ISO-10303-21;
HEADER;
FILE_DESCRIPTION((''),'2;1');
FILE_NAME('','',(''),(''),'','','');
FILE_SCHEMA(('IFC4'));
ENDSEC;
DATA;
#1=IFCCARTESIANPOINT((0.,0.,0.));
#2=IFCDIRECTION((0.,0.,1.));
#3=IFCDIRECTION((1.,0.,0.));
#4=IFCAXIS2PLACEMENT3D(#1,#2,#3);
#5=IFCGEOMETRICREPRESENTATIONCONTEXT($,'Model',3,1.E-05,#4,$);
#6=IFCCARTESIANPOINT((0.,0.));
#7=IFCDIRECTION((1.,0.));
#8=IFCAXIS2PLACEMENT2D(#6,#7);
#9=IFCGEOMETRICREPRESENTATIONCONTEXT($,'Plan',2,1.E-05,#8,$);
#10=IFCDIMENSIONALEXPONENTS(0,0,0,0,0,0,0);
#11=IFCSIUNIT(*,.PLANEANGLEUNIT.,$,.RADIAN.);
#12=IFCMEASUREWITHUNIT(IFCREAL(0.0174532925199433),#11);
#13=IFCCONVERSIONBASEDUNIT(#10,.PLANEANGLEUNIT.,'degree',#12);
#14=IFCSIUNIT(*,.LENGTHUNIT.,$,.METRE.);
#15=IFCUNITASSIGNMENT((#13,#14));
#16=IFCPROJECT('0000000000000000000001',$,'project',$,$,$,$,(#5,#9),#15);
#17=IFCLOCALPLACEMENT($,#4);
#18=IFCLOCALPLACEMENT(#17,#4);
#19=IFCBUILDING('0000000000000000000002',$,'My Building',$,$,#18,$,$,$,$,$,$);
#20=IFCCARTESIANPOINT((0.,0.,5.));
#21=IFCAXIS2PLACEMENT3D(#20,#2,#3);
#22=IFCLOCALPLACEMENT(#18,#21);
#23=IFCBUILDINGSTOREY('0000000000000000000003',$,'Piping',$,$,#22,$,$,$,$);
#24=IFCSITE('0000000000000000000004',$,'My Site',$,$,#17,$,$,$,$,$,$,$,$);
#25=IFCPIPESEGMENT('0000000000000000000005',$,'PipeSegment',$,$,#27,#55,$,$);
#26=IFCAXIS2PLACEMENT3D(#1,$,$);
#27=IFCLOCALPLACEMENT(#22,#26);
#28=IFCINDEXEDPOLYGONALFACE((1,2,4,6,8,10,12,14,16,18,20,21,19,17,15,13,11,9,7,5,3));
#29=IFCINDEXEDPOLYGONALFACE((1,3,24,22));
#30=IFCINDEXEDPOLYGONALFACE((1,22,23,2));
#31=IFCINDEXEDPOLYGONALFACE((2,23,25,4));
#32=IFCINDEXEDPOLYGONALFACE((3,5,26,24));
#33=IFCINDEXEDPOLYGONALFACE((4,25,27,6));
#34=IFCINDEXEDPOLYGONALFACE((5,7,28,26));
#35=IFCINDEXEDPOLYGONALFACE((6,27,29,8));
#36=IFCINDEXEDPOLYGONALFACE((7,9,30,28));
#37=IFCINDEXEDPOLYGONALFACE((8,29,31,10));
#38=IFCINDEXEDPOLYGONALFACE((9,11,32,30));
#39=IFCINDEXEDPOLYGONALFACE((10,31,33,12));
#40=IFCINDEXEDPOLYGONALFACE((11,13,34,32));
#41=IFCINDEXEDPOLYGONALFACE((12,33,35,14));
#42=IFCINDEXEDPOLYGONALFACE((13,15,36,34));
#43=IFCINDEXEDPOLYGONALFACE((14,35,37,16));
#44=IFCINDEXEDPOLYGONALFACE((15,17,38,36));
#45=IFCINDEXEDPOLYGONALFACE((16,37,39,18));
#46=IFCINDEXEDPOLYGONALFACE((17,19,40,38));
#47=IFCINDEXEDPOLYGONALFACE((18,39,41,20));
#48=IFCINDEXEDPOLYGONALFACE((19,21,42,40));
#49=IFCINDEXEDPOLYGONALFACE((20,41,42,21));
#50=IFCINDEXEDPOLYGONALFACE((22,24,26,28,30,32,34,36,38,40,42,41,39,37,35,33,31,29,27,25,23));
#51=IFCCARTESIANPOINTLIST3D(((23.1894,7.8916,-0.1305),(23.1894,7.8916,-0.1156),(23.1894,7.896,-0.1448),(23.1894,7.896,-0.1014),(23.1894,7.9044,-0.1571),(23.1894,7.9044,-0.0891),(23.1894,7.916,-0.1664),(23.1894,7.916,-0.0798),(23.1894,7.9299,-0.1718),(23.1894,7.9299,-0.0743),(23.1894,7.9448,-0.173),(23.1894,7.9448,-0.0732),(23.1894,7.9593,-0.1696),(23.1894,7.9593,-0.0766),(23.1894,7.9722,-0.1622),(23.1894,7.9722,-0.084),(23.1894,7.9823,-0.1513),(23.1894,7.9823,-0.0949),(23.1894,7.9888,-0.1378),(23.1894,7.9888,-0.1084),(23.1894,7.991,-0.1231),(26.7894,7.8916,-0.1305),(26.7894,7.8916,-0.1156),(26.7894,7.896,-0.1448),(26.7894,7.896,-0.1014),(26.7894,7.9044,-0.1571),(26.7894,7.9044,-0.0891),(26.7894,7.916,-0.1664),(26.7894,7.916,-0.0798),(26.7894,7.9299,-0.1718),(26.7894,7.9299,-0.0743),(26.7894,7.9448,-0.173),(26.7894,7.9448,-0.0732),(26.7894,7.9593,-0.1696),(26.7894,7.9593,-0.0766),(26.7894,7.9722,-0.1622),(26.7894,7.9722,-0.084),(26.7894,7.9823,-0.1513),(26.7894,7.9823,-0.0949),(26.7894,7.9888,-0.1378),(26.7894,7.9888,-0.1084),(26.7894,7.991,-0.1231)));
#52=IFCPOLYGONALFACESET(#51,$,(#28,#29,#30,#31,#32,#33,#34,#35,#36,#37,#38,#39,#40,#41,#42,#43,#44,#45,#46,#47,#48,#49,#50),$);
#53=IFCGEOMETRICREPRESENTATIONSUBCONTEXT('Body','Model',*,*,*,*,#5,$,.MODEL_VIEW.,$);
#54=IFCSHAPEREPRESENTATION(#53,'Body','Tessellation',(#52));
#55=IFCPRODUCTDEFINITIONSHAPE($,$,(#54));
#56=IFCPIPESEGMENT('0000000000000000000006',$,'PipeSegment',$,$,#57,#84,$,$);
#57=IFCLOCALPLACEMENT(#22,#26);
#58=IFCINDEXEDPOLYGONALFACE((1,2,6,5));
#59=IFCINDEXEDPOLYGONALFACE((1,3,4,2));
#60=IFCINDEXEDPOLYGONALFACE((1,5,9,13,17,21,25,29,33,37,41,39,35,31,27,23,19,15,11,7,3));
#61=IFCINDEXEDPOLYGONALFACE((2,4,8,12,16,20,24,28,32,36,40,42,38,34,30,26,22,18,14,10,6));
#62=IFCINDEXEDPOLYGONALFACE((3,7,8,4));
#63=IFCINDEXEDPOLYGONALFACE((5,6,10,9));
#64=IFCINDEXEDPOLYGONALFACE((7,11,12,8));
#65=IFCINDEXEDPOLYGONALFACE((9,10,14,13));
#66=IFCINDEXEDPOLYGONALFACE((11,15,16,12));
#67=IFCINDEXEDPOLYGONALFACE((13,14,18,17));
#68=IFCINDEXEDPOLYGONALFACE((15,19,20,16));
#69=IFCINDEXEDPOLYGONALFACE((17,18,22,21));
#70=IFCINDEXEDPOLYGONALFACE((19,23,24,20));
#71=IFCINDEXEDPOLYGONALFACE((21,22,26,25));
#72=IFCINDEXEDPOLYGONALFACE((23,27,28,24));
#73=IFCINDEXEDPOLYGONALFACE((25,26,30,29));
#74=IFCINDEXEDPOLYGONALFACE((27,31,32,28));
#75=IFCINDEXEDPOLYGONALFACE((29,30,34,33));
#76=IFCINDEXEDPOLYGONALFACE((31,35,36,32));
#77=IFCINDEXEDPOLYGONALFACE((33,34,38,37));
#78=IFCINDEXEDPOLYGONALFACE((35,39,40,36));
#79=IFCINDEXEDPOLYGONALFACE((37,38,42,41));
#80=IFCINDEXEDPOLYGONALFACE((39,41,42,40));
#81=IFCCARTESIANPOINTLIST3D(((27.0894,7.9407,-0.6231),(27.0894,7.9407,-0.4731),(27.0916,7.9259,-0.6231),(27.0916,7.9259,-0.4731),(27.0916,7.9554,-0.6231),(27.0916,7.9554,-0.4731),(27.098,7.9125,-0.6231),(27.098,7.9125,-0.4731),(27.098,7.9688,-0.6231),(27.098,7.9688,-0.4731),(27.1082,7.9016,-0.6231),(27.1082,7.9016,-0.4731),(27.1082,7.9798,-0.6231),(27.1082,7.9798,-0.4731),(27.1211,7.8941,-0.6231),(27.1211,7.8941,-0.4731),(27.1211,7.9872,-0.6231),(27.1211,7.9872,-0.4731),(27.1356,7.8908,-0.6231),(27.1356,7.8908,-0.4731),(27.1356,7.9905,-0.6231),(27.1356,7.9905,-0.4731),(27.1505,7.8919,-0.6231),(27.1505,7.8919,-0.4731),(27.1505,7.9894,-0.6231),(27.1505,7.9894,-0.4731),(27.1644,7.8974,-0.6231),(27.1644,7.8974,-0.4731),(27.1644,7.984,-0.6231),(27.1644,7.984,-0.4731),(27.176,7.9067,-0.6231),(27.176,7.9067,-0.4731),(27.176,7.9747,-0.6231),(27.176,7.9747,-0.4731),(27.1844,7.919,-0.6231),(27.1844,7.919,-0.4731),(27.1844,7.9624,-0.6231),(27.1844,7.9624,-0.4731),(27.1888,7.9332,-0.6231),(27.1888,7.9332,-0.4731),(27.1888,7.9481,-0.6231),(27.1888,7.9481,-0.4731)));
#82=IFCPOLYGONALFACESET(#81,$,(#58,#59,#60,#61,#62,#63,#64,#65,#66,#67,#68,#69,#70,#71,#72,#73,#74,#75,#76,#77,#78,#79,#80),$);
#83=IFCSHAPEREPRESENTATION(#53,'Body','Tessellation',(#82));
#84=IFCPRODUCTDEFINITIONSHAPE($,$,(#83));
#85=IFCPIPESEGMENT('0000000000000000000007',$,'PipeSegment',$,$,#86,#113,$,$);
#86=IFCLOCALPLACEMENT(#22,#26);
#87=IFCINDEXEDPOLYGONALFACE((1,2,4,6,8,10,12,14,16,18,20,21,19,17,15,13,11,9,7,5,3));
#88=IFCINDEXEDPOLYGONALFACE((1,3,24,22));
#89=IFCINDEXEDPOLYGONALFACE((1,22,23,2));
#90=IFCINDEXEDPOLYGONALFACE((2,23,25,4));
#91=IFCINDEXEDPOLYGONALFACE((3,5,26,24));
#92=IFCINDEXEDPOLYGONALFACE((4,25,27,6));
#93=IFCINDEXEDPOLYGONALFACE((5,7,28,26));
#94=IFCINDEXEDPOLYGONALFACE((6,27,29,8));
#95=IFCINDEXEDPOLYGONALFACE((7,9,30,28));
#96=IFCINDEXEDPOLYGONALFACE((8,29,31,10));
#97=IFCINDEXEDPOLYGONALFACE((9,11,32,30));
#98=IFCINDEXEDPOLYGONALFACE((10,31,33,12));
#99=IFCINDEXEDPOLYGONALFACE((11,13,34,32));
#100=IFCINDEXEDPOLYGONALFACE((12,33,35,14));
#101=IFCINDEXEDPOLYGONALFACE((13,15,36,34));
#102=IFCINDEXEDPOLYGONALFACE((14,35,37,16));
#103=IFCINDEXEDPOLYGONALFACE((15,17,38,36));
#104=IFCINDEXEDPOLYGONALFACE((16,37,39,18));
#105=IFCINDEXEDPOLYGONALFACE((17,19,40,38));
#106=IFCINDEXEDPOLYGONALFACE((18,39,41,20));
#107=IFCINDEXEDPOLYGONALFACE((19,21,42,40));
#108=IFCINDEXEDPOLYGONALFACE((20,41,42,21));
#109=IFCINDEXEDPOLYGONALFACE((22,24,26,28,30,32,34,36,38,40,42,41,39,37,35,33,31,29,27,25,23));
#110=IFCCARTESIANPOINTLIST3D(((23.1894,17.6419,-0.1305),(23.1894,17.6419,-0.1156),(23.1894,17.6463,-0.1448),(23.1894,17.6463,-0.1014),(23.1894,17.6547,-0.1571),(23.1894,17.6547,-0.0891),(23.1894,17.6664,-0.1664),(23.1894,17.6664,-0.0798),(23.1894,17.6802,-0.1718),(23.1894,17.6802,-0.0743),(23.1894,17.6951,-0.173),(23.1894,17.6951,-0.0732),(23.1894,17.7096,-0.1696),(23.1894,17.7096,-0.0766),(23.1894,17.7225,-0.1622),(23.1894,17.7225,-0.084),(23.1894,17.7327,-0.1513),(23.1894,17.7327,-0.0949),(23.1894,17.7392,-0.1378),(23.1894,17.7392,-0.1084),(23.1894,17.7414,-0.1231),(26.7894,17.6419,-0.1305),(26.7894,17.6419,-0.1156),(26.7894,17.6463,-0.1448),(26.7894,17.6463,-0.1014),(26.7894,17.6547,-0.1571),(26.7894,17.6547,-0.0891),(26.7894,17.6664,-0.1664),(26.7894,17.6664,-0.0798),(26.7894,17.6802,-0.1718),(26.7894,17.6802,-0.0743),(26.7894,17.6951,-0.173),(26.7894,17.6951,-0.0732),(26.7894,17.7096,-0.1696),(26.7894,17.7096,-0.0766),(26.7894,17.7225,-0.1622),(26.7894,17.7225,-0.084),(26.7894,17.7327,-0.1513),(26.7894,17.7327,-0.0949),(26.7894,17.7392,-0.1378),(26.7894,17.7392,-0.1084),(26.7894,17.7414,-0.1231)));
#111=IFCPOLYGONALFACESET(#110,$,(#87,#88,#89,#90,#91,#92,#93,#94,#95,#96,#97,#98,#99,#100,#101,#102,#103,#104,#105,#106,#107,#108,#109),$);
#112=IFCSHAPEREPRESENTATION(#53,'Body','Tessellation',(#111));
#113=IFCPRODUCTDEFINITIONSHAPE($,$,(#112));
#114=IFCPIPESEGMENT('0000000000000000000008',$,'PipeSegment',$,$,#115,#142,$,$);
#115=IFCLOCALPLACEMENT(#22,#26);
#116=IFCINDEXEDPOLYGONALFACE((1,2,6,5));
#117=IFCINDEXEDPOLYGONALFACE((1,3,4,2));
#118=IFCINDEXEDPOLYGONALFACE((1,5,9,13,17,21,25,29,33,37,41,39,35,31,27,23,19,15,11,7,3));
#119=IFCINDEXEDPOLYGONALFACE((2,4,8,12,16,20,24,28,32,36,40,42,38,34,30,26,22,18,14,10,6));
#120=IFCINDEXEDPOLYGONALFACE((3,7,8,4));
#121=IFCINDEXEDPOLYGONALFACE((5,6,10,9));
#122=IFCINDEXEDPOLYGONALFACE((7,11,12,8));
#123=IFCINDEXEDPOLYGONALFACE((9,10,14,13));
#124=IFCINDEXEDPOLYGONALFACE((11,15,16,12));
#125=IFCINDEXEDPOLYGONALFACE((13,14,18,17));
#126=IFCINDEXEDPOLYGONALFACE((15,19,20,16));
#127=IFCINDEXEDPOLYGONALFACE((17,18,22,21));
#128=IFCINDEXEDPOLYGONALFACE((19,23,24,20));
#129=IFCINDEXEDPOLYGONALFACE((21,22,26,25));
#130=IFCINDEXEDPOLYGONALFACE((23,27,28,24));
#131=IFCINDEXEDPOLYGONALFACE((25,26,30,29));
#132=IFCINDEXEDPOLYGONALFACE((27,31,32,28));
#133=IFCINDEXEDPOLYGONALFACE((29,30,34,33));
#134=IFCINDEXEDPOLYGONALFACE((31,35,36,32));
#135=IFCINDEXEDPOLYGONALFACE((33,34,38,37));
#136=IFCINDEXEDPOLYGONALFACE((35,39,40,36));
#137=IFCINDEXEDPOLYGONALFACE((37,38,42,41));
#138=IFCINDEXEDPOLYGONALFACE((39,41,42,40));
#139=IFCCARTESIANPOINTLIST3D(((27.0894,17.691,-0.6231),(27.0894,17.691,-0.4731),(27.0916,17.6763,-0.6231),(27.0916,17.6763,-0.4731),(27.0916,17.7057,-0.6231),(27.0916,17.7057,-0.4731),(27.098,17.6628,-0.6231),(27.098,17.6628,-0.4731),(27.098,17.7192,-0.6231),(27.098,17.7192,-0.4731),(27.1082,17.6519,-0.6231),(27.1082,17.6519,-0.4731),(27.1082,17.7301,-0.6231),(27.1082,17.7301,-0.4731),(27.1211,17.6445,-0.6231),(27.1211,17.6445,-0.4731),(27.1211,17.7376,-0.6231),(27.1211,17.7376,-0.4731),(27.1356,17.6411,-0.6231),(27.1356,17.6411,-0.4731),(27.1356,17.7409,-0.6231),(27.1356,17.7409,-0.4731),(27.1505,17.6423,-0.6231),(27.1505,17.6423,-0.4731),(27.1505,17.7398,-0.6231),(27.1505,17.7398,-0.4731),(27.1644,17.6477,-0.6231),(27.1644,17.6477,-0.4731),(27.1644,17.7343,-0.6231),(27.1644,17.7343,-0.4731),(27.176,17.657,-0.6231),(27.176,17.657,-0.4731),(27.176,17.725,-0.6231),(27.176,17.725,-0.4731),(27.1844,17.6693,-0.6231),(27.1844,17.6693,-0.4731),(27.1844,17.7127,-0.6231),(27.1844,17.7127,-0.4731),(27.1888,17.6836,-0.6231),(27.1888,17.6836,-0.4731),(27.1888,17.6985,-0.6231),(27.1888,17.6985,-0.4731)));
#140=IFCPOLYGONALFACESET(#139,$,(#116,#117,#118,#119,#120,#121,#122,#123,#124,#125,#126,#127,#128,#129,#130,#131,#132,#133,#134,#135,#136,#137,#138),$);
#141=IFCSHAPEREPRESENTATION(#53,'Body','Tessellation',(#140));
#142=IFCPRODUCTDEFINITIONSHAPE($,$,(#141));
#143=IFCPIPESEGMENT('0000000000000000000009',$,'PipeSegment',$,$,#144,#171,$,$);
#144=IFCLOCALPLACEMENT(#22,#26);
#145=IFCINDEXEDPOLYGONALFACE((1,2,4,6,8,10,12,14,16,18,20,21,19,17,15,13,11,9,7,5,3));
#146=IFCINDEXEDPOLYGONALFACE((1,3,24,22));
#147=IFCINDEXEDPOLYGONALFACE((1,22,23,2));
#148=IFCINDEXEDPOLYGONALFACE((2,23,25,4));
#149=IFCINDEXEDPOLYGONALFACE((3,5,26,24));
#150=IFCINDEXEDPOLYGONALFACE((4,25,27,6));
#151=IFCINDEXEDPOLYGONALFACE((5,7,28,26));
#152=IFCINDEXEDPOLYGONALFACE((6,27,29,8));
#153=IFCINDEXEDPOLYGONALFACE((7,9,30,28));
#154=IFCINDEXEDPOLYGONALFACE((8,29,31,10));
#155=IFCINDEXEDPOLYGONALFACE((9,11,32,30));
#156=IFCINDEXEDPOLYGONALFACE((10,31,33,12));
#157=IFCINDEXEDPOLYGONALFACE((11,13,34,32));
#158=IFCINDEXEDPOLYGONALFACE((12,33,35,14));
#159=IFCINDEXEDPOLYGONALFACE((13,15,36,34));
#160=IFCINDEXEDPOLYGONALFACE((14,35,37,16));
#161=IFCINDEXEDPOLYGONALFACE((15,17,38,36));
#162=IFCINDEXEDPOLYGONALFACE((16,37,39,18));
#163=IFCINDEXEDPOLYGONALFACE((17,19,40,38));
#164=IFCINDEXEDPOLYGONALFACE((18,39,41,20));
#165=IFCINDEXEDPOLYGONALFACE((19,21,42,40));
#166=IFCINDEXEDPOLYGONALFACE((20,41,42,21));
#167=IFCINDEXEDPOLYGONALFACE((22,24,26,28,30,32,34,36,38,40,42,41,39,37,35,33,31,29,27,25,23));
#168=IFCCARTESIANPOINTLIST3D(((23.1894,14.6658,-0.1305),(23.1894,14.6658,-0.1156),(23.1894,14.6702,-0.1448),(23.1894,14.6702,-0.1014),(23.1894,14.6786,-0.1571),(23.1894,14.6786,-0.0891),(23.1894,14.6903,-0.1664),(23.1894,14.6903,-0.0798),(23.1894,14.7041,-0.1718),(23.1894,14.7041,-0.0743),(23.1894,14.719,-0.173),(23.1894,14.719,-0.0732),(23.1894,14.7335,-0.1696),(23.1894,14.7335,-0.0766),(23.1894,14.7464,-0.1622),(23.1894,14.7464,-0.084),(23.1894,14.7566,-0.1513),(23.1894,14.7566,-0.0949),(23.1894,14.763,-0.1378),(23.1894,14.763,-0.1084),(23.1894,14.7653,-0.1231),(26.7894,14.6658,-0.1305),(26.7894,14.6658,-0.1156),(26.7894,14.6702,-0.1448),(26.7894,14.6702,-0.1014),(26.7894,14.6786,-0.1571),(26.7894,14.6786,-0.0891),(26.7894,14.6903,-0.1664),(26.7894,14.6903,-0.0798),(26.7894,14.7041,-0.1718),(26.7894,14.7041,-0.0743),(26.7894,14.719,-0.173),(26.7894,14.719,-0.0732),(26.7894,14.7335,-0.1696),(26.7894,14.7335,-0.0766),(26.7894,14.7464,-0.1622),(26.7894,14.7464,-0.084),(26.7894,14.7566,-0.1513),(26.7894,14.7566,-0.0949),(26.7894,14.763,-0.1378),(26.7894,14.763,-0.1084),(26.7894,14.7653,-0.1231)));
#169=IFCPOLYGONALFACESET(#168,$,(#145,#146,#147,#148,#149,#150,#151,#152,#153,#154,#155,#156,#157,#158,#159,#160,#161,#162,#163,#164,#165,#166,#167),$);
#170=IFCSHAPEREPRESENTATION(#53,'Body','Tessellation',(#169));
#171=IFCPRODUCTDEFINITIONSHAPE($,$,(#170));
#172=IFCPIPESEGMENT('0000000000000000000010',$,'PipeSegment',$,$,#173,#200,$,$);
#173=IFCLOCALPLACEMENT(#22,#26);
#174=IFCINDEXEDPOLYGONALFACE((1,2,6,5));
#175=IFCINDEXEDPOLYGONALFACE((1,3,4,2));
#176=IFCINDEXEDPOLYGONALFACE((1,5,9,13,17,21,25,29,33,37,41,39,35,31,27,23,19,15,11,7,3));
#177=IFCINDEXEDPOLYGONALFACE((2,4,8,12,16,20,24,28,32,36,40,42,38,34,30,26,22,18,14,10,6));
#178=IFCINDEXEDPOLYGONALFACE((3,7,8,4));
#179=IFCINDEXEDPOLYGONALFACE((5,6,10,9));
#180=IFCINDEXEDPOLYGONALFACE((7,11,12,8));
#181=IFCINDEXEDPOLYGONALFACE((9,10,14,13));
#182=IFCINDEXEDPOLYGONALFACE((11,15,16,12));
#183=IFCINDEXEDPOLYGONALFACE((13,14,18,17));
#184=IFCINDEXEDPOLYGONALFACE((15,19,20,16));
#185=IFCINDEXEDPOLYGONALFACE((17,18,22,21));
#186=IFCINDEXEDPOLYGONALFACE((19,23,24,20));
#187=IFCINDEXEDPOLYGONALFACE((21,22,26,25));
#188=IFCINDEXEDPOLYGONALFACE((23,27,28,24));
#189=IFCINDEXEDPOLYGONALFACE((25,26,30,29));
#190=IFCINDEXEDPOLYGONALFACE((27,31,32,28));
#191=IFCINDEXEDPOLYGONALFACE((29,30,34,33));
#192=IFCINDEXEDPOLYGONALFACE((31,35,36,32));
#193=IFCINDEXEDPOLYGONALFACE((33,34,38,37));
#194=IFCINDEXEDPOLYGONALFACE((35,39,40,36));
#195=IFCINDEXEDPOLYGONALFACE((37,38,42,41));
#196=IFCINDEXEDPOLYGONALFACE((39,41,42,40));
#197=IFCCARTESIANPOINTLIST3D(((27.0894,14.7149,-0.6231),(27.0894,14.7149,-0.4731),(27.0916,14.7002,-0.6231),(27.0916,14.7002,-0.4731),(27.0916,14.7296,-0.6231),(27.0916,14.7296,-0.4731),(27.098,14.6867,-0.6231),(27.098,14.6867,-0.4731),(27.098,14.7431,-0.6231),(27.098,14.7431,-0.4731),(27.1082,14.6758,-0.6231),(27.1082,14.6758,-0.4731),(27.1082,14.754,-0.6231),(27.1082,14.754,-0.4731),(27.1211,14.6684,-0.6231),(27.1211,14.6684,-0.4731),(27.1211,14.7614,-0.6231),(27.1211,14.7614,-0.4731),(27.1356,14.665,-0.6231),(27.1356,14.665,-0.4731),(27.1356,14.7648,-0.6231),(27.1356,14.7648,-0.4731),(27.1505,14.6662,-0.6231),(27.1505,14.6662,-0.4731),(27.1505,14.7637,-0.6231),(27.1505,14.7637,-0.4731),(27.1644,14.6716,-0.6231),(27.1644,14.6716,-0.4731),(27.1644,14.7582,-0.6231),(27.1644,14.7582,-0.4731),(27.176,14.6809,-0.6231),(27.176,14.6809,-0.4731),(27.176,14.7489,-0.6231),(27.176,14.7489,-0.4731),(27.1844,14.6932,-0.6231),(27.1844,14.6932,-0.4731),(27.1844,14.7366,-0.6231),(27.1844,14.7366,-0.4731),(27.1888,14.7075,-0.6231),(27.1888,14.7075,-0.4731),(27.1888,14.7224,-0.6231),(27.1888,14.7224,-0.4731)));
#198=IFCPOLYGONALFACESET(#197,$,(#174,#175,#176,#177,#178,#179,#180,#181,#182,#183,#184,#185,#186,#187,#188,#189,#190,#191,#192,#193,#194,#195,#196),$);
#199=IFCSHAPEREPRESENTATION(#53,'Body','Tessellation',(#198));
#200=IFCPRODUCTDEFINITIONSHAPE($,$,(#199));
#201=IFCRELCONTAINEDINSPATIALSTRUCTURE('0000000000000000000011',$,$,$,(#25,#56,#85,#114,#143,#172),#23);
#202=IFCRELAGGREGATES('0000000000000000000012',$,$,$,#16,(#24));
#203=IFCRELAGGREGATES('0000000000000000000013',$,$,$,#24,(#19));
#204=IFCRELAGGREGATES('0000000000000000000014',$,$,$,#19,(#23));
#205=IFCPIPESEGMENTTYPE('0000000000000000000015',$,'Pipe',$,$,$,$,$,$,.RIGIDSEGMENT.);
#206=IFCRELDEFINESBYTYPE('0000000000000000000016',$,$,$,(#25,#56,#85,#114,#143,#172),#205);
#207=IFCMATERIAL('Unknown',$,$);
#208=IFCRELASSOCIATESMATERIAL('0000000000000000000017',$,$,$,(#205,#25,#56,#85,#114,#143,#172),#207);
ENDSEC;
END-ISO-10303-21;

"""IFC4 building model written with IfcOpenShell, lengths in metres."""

from ifc_helpers import new_model, entity, si_unit, converted_unit, frame, origin_with_axes, origin_2d_with_axis, place, context, subcontext, project, spatial, circle, extrude, material, material_profile, profile_set, profile_usage, type_object, element, save


model = new_model("IFC4")

# Units and contexts
model_context = context("Model", 3, precision=1e-05, world=origin_with_axes())
plan_context = context("Plan", 2, precision=1e-05, world=origin_2d_with_axis())
body_context = subcontext(model_context, "Body", "Model", "MODEL_VIEW")
ifc_project = project(units=[converted_unit("PLANEANGLEUNIT", "degree", entity("IfcReal", 0.0174532925199433), si_unit("PLANEANGLEUNIT", "RADIAN"), dimensions=[0, 0, 0, 0, 0, 0, 0]), si_unit("LENGTHUNIT", "METRE")], contexts=[model_context, plan_context])

# Site, building, storey
site_placement = place(None, origin_with_axes())
site = spatial("IfcSite", under=ifc_project, at=site_placement, Name="My Site")
building_placement = place(site_placement, origin_with_axes())
building = spatial("IfcBuilding", under=site, at=building_placement, Name="My Building")
storey_placement = place(building_placement, frame((0.0, 0.0, 5.0), z_axis=(0.0, 0.0, 1.0), x_axis=(1.0, 0.0, 0.0)))
storey = spatial("IfcBuildingStorey", under=building, at=storey_placement, Name="Piping")

# Pipe segments
ifc_material = material(Name="Unknown")
ifc_material_profile_1 = material_profile(ifc_material, circle(Radius=0.05))
ifc_profile_set_1 = profile_set([ifc_material_profile_1])
pipe_segment_type = type_object("IfcPipeSegmentType", Name="Pipe", PredefinedType="RIGIDSEGMENT", material=ifc_profile_set_1)
ifc_profile_usage_1 = profile_usage(ifc_profile_set_1, cardinal=5)
pipe_segment_1_placement = place(storey_placement, frame((23.1894, 7.941, -0.1231), z_axis=(1.0, 0.0, 0.0), x_axis=(0.0, 1.0, 0.0)))
element("IfcPipeSegment", 1, at=pipe_segment_1_placement, inside=storey, type_object=pipe_segment_type, material=ifc_profile_usage_1, Name="PipeSegment", context=body_context, shape_type="SweptSolid", body=[
    extrude(circle(Radius=0.05), origin_with_axes(), (0.0, 0.0, 1.0), 3.6),
])
ifc_profile_usage_2 = profile_usage(ifc_profile_set_1, cardinal=5)
pipe_segment_2_placement = place(storey_placement, frame((27.1394, 7.9407, -0.4731), z_axis=(0.0, 0.0, -1.0), x_axis=(-1.0, 0.0, 0.0)))
element("IfcPipeSegment", 2, at=pipe_segment_2_placement, inside=storey, type_object=pipe_segment_type, material=ifc_profile_usage_2, Name="PipeSegment", context=body_context, shape_type="SweptSolid", body=[
    extrude(circle(Radius=0.05), origin_with_axes(), (0.0, 0.0, 1.0), 0.15),
])
ifc_profile_usage_3 = profile_usage(ifc_profile_set_1, cardinal=5)
pipe_segment_3_placement = place(storey_placement, frame((23.1894, 17.6914, -0.1231), z_axis=(1.0, 0.0, 0.0), x_axis=(0.0, 1.0, 0.0)))
element("IfcPipeSegment", 3, at=pipe_segment_3_placement, inside=storey, type_object=pipe_segment_type, material=ifc_profile_usage_3, Name="PipeSegment", context=body_context, shape_type="SweptSolid", body=[
    extrude(circle(Radius=0.05), origin_with_axes(), (0.0, 0.0, 1.0), 3.6),
])
ifc_profile_usage_4 = profile_usage(ifc_profile_set_1, cardinal=5)
pipe_segment_4_placement = place(storey_placement, frame((27.1394, 17.691, -0.4731), z_axis=(0.0, 0.0, -1.0), x_axis=(-1.0, 0.0, 0.0)))
element("IfcPipeSegment", 4, at=pipe_segment_4_placement, inside=storey, type_object=pipe_segment_type, material=ifc_profile_usage_4, Name="PipeSegment", context=body_context, shape_type="SweptSolid", body=[
    extrude(circle(Radius=0.05), origin_with_axes(), (0.0, 0.0, 1.0), 0.15),
])
ifc_profile_usage_5 = profile_usage(ifc_profile_set_1, cardinal=5)
pipe_segment_5_placement = place(storey_placement, frame((23.1894, 14.7153, -0.1231), z_axis=(1.0, 0.0, 0.0), x_axis=(0.0, 1.0, 0.0)))
element("IfcPipeSegment", 5, at=pipe_segment_5_placement, inside=storey, type_object=pipe_segment_type, material=ifc_profile_usage_5, Name="PipeSegment", context=body_context, shape_type="SweptSolid", body=[
    extrude(circle(Radius=0.05), origin_with_axes(), (0.0, 0.0, 1.0), 3.6),
])
ifc_profile_usage_6 = profile_usage(ifc_profile_set_1, cardinal=5)
pipe_segment_6_placement = place(storey_placement, frame((27.1394, 14.7149, -0.4731), z_axis=(0.0, 0.0, -1.0), x_axis=(-1.0, 0.0, 0.0)))
element("IfcPipeSegment", 6, at=pipe_segment_6_placement, inside=storey, type_object=pipe_segment_type, material=ifc_profile_usage_6, Name="PipeSegment", context=body_context, shape_type="SweptSolid", body=[
    extrude(circle(Radius=0.05), origin_with_axes(), (0.0, 0.0, 1.0), 0.15),
])

save(model, "model.ifc")
